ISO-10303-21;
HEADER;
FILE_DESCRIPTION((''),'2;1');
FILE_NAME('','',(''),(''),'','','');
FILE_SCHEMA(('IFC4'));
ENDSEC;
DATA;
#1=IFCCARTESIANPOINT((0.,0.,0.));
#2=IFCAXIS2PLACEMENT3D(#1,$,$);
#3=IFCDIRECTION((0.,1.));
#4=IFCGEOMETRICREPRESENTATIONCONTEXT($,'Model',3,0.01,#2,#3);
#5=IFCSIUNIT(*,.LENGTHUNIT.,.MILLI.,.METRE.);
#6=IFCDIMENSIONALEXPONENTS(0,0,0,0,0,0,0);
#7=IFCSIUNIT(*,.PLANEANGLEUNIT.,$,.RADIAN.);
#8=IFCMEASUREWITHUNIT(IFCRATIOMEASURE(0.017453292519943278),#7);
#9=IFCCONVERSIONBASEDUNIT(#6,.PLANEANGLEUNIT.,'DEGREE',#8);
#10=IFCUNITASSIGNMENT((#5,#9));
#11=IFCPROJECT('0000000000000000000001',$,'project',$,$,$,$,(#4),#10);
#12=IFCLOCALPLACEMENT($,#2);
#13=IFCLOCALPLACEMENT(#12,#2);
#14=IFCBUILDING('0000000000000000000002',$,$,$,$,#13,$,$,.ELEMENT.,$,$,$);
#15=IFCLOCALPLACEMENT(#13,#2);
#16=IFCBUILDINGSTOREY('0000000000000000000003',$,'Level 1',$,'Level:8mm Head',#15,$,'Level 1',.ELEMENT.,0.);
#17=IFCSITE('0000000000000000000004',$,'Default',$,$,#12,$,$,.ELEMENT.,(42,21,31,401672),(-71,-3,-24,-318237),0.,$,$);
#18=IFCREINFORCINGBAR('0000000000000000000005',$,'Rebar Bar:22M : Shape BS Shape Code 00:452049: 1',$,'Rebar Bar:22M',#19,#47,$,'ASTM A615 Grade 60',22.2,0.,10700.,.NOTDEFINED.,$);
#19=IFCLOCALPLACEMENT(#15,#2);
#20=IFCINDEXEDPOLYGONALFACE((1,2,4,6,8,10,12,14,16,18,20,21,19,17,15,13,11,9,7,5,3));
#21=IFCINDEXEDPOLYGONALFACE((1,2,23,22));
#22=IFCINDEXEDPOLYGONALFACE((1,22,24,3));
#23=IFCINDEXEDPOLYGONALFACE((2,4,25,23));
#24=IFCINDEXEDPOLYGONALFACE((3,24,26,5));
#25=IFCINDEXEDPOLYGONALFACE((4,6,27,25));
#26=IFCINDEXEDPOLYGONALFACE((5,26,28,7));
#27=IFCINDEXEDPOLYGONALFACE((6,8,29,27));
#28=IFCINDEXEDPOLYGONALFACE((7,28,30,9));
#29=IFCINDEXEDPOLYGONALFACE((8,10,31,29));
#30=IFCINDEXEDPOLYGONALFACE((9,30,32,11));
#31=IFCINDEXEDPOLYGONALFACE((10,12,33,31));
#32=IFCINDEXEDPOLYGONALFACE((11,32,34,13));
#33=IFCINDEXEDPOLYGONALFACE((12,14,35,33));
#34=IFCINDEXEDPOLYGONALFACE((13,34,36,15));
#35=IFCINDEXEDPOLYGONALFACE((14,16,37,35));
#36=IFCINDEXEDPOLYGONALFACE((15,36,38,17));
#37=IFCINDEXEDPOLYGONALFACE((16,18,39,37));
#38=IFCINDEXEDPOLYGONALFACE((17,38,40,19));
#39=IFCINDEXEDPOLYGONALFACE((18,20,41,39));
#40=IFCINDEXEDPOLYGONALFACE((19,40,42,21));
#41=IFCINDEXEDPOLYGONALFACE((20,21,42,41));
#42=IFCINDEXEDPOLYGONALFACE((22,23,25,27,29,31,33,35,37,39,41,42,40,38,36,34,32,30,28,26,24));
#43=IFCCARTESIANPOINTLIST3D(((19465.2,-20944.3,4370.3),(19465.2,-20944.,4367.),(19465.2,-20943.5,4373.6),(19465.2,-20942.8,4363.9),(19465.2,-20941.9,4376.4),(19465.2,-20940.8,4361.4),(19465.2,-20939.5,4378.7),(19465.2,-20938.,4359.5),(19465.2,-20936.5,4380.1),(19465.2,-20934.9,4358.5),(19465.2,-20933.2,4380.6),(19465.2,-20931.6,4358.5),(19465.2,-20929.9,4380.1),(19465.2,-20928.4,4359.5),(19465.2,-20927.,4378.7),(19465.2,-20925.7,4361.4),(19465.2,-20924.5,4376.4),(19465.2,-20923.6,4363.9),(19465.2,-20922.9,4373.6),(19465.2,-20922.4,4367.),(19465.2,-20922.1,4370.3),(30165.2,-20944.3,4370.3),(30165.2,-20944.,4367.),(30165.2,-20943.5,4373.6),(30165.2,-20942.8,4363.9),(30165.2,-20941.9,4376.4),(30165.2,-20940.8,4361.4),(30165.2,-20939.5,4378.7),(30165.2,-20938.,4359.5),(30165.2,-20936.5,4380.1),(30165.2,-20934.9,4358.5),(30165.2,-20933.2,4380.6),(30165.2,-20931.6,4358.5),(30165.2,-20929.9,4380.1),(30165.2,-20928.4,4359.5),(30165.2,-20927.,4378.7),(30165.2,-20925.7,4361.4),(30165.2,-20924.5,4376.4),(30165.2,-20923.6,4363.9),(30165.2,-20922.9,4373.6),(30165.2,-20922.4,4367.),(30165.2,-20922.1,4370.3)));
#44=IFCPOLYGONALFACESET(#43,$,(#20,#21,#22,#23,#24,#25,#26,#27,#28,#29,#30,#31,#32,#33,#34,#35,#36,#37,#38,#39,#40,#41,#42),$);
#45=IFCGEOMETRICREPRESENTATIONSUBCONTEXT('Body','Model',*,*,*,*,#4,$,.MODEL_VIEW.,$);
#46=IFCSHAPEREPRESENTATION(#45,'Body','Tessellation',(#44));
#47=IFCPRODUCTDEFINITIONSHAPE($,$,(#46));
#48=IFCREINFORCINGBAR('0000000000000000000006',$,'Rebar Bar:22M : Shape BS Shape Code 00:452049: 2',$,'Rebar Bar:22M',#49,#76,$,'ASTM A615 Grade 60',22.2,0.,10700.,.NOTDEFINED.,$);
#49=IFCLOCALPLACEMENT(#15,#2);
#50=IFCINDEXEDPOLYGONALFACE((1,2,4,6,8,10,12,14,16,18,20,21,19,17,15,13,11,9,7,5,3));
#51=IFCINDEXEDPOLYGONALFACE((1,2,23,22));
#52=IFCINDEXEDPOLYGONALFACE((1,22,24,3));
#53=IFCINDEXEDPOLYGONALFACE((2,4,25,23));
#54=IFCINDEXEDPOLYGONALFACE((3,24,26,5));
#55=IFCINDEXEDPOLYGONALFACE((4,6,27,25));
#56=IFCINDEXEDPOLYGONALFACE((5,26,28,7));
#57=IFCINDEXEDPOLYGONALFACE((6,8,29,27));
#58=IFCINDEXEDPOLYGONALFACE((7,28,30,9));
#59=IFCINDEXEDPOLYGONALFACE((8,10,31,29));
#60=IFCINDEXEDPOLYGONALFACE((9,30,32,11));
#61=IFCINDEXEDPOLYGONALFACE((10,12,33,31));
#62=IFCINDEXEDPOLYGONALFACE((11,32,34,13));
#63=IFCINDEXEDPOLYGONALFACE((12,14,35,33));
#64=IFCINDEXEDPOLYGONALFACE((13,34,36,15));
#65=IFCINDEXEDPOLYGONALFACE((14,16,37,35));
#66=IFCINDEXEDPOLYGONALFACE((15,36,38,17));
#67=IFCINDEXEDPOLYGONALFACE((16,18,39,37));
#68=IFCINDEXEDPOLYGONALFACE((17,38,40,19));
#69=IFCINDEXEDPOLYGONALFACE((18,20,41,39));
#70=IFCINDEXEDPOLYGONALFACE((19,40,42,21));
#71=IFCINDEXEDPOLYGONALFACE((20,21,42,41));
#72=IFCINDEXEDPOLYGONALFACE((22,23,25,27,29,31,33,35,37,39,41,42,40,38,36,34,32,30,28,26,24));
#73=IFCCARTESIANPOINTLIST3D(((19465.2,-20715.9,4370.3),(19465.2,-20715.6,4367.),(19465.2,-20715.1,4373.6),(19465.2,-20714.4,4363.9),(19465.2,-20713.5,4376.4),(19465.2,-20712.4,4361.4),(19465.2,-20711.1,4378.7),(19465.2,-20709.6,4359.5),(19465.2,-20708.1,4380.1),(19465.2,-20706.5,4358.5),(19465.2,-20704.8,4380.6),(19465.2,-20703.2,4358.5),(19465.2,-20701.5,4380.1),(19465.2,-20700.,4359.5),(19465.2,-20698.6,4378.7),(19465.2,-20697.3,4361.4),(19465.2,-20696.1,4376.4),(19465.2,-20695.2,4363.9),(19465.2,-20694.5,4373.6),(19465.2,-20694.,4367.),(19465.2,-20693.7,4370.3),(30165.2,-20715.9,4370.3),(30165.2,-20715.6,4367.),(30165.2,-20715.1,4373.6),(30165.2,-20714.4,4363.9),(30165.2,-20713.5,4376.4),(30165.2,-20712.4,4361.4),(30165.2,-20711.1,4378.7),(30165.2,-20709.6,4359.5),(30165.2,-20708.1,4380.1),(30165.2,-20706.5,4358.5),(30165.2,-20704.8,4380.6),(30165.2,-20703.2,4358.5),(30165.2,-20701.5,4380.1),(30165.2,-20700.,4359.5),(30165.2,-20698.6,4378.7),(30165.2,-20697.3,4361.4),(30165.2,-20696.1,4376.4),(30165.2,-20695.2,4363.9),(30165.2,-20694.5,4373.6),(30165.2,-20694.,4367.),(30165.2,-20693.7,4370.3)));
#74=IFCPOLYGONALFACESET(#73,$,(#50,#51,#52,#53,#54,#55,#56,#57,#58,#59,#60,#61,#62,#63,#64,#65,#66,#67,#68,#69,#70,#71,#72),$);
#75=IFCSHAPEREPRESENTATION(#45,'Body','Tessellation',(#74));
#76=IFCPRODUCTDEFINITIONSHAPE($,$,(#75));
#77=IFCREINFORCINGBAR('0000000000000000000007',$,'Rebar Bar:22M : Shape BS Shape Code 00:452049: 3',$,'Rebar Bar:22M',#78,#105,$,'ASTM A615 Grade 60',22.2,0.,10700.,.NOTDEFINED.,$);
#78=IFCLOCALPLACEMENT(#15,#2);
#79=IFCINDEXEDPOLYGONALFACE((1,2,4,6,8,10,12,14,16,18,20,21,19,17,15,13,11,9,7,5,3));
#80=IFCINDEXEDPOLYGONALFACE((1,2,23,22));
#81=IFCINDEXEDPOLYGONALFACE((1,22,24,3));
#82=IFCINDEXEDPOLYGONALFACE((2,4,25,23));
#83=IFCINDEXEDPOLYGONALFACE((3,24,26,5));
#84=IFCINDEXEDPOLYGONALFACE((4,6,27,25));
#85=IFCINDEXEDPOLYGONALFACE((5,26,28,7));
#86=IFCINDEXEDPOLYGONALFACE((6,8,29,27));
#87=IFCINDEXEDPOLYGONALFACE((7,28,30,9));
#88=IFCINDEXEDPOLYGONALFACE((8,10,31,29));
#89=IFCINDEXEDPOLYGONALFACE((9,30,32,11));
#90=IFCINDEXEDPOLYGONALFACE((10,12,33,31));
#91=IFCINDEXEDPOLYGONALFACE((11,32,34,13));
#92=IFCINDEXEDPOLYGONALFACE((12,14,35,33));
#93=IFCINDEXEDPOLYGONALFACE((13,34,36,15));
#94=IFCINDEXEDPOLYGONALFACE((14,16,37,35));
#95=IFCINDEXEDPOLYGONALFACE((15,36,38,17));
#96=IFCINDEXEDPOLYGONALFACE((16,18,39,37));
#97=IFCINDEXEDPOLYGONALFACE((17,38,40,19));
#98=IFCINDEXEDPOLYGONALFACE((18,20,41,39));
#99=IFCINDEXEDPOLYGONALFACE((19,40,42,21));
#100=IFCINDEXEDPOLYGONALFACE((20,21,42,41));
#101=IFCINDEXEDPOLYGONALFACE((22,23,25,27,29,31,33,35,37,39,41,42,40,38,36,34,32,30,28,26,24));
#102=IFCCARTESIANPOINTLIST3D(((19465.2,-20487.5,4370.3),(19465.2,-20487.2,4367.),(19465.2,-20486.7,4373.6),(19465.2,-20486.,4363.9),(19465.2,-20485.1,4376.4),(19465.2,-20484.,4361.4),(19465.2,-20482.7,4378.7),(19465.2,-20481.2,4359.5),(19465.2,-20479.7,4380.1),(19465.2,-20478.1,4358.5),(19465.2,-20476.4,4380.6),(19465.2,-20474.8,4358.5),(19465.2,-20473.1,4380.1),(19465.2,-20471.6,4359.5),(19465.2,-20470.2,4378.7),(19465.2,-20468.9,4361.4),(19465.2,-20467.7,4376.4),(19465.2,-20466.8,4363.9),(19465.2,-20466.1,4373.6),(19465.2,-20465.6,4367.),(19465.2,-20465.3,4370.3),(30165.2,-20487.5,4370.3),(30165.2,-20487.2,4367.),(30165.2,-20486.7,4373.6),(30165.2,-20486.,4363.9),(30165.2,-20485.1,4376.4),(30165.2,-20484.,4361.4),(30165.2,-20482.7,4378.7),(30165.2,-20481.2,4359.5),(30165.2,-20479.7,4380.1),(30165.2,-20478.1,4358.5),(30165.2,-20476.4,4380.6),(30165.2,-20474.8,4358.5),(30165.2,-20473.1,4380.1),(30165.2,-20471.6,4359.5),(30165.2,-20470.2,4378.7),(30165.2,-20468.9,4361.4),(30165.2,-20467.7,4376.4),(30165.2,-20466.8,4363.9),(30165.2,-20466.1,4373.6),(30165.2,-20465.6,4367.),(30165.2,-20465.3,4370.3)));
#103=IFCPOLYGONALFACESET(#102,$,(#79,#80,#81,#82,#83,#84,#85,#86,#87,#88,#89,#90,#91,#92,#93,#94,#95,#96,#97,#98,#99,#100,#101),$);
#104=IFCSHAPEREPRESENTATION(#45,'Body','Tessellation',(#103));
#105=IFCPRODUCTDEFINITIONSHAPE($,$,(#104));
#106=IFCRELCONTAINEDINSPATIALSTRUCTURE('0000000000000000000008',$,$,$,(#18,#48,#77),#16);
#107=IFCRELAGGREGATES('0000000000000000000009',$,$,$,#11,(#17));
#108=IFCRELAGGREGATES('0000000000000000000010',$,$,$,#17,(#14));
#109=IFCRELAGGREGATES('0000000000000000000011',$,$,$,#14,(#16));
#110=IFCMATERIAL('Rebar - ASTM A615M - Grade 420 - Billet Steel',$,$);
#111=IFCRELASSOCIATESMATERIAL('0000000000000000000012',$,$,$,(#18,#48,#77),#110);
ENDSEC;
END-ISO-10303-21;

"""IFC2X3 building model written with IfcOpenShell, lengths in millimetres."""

from ifc_helpers import new_model, entity, si_unit, converted_unit, direction, origin, place, context, subcontext, project, spatial, material, element, save


model = new_model("IFC2X3")

# Units and contexts
model_context = context("Model", 3, precision=0.01, world=origin(), true_north=direction((0.0, 1.0)))
body_context = subcontext(model_context, "Body", "Model", "MODEL_VIEW")
ifc_project = project(units=[si_unit("LENGTHUNIT", "METRE", prefix="MILLI"), converted_unit("PLANEANGLEUNIT", "DEGREE", entity("IfcRatioMeasure", 0.017453292519943278), si_unit("PLANEANGLEUNIT", "RADIAN"), dimensions=[0, 0, 0, 0, 0, 0, 0])], contexts=[model_context])

# Site, building, storey
site_placement = place(None, origin())
site = spatial("IfcSite", under=ifc_project, at=site_placement, Name="Default", CompositionType="ELEMENT", RefLatitude=(42, 21, 31, 401672), RefLongitude=(-71, -3, -24, -318237), RefElevation=0.0)
building_placement = place(site_placement, origin())
building = spatial("IfcBuilding", under=site, at=building_placement, CompositionType="ELEMENT")
storey_placement = place(building_placement, origin())
storey = spatial("IfcBuildingStorey", under=building, at=storey_placement, Name="Level 1", ObjectType="Level:8mm Head", LongName="Level 1", CompositionType="ELEMENT", Elevation=0.0)

# Reinforcing bars
ifc_material = material(Name="Rebar - ASTM A615M - Grade 420 - Billet Steel")
reinforcing_bar_1_placement = place(storey_placement, origin())
element("IfcReinforcingBar", 1, at=reinforcing_bar_1_placement, inside=storey, material=ifc_material, Name="Rebar Bar:22M : Shape BS Shape Code 00:452049: 1", SteelGrade="ASTM A615 Grade 60", ObjectType="Rebar Bar:22M", BarLength=10700.0, BarRole="NOTDEFINED", CrossSectionArea=0.0, NominalDiameter=22.2, context=body_context, shape_type="AdvancedSweptSolid", body=[
    entity("IfcSweptDiskSolid", entity("IfcCompositeCurve", [entity("IfcCompositeCurveSegment", "CONTINUOUS", True, entity("IfcPolyline", [entity("IfcCartesianPoint", [19465.2, -20933.2, 4369.5]), entity("IfcCartesianPoint", [30165.2, -20933.2, 4369.5])]))], False), 11.1, None, 0.0, 1.0),
])
reinforcing_bar_2_placement = place(storey_placement, origin())
element("IfcReinforcingBar", 2, at=reinforcing_bar_2_placement, inside=storey, material=ifc_material, Name="Rebar Bar:22M : Shape BS Shape Code 00:452049: 2", SteelGrade="ASTM A615 Grade 60", ObjectType="Rebar Bar:22M", BarLength=10700.0, BarRole="NOTDEFINED", CrossSectionArea=0.0, NominalDiameter=22.2, context=body_context, shape_type="AdvancedSweptSolid", body=[
    entity("IfcSweptDiskSolid", entity("IfcCompositeCurve", [entity("IfcCompositeCurveSegment", "CONTINUOUS", True, entity("IfcPolyline", [entity("IfcCartesianPoint", [19465.2, -20704.8, 4369.5]), entity("IfcCartesianPoint", [30165.2, -20704.8, 4369.5])]))], False), 11.1, None, 0.0, 1.0),
])
reinforcing_bar_3_placement = place(storey_placement, origin())
element("IfcReinforcingBar", 3, at=reinforcing_bar_3_placement, inside=storey, material=ifc_material, Name="Rebar Bar:22M : Shape BS Shape Code 00:452049: 3", SteelGrade="ASTM A615 Grade 60", ObjectType="Rebar Bar:22M", BarLength=10700.0, BarRole="NOTDEFINED", CrossSectionArea=0.0, NominalDiameter=22.2, context=body_context, shape_type="AdvancedSweptSolid", body=[
    entity("IfcSweptDiskSolid", entity("IfcCompositeCurve", [entity("IfcCompositeCurveSegment", "CONTINUOUS", True, entity("IfcPolyline", [entity("IfcCartesianPoint", [19465.2, -20476.4, 4369.5]), entity("IfcCartesianPoint", [30165.2, -20476.4, 4369.5])]))], False), 11.1, None, 0.0, 1.0),
])

save(model, "model.ifc")
